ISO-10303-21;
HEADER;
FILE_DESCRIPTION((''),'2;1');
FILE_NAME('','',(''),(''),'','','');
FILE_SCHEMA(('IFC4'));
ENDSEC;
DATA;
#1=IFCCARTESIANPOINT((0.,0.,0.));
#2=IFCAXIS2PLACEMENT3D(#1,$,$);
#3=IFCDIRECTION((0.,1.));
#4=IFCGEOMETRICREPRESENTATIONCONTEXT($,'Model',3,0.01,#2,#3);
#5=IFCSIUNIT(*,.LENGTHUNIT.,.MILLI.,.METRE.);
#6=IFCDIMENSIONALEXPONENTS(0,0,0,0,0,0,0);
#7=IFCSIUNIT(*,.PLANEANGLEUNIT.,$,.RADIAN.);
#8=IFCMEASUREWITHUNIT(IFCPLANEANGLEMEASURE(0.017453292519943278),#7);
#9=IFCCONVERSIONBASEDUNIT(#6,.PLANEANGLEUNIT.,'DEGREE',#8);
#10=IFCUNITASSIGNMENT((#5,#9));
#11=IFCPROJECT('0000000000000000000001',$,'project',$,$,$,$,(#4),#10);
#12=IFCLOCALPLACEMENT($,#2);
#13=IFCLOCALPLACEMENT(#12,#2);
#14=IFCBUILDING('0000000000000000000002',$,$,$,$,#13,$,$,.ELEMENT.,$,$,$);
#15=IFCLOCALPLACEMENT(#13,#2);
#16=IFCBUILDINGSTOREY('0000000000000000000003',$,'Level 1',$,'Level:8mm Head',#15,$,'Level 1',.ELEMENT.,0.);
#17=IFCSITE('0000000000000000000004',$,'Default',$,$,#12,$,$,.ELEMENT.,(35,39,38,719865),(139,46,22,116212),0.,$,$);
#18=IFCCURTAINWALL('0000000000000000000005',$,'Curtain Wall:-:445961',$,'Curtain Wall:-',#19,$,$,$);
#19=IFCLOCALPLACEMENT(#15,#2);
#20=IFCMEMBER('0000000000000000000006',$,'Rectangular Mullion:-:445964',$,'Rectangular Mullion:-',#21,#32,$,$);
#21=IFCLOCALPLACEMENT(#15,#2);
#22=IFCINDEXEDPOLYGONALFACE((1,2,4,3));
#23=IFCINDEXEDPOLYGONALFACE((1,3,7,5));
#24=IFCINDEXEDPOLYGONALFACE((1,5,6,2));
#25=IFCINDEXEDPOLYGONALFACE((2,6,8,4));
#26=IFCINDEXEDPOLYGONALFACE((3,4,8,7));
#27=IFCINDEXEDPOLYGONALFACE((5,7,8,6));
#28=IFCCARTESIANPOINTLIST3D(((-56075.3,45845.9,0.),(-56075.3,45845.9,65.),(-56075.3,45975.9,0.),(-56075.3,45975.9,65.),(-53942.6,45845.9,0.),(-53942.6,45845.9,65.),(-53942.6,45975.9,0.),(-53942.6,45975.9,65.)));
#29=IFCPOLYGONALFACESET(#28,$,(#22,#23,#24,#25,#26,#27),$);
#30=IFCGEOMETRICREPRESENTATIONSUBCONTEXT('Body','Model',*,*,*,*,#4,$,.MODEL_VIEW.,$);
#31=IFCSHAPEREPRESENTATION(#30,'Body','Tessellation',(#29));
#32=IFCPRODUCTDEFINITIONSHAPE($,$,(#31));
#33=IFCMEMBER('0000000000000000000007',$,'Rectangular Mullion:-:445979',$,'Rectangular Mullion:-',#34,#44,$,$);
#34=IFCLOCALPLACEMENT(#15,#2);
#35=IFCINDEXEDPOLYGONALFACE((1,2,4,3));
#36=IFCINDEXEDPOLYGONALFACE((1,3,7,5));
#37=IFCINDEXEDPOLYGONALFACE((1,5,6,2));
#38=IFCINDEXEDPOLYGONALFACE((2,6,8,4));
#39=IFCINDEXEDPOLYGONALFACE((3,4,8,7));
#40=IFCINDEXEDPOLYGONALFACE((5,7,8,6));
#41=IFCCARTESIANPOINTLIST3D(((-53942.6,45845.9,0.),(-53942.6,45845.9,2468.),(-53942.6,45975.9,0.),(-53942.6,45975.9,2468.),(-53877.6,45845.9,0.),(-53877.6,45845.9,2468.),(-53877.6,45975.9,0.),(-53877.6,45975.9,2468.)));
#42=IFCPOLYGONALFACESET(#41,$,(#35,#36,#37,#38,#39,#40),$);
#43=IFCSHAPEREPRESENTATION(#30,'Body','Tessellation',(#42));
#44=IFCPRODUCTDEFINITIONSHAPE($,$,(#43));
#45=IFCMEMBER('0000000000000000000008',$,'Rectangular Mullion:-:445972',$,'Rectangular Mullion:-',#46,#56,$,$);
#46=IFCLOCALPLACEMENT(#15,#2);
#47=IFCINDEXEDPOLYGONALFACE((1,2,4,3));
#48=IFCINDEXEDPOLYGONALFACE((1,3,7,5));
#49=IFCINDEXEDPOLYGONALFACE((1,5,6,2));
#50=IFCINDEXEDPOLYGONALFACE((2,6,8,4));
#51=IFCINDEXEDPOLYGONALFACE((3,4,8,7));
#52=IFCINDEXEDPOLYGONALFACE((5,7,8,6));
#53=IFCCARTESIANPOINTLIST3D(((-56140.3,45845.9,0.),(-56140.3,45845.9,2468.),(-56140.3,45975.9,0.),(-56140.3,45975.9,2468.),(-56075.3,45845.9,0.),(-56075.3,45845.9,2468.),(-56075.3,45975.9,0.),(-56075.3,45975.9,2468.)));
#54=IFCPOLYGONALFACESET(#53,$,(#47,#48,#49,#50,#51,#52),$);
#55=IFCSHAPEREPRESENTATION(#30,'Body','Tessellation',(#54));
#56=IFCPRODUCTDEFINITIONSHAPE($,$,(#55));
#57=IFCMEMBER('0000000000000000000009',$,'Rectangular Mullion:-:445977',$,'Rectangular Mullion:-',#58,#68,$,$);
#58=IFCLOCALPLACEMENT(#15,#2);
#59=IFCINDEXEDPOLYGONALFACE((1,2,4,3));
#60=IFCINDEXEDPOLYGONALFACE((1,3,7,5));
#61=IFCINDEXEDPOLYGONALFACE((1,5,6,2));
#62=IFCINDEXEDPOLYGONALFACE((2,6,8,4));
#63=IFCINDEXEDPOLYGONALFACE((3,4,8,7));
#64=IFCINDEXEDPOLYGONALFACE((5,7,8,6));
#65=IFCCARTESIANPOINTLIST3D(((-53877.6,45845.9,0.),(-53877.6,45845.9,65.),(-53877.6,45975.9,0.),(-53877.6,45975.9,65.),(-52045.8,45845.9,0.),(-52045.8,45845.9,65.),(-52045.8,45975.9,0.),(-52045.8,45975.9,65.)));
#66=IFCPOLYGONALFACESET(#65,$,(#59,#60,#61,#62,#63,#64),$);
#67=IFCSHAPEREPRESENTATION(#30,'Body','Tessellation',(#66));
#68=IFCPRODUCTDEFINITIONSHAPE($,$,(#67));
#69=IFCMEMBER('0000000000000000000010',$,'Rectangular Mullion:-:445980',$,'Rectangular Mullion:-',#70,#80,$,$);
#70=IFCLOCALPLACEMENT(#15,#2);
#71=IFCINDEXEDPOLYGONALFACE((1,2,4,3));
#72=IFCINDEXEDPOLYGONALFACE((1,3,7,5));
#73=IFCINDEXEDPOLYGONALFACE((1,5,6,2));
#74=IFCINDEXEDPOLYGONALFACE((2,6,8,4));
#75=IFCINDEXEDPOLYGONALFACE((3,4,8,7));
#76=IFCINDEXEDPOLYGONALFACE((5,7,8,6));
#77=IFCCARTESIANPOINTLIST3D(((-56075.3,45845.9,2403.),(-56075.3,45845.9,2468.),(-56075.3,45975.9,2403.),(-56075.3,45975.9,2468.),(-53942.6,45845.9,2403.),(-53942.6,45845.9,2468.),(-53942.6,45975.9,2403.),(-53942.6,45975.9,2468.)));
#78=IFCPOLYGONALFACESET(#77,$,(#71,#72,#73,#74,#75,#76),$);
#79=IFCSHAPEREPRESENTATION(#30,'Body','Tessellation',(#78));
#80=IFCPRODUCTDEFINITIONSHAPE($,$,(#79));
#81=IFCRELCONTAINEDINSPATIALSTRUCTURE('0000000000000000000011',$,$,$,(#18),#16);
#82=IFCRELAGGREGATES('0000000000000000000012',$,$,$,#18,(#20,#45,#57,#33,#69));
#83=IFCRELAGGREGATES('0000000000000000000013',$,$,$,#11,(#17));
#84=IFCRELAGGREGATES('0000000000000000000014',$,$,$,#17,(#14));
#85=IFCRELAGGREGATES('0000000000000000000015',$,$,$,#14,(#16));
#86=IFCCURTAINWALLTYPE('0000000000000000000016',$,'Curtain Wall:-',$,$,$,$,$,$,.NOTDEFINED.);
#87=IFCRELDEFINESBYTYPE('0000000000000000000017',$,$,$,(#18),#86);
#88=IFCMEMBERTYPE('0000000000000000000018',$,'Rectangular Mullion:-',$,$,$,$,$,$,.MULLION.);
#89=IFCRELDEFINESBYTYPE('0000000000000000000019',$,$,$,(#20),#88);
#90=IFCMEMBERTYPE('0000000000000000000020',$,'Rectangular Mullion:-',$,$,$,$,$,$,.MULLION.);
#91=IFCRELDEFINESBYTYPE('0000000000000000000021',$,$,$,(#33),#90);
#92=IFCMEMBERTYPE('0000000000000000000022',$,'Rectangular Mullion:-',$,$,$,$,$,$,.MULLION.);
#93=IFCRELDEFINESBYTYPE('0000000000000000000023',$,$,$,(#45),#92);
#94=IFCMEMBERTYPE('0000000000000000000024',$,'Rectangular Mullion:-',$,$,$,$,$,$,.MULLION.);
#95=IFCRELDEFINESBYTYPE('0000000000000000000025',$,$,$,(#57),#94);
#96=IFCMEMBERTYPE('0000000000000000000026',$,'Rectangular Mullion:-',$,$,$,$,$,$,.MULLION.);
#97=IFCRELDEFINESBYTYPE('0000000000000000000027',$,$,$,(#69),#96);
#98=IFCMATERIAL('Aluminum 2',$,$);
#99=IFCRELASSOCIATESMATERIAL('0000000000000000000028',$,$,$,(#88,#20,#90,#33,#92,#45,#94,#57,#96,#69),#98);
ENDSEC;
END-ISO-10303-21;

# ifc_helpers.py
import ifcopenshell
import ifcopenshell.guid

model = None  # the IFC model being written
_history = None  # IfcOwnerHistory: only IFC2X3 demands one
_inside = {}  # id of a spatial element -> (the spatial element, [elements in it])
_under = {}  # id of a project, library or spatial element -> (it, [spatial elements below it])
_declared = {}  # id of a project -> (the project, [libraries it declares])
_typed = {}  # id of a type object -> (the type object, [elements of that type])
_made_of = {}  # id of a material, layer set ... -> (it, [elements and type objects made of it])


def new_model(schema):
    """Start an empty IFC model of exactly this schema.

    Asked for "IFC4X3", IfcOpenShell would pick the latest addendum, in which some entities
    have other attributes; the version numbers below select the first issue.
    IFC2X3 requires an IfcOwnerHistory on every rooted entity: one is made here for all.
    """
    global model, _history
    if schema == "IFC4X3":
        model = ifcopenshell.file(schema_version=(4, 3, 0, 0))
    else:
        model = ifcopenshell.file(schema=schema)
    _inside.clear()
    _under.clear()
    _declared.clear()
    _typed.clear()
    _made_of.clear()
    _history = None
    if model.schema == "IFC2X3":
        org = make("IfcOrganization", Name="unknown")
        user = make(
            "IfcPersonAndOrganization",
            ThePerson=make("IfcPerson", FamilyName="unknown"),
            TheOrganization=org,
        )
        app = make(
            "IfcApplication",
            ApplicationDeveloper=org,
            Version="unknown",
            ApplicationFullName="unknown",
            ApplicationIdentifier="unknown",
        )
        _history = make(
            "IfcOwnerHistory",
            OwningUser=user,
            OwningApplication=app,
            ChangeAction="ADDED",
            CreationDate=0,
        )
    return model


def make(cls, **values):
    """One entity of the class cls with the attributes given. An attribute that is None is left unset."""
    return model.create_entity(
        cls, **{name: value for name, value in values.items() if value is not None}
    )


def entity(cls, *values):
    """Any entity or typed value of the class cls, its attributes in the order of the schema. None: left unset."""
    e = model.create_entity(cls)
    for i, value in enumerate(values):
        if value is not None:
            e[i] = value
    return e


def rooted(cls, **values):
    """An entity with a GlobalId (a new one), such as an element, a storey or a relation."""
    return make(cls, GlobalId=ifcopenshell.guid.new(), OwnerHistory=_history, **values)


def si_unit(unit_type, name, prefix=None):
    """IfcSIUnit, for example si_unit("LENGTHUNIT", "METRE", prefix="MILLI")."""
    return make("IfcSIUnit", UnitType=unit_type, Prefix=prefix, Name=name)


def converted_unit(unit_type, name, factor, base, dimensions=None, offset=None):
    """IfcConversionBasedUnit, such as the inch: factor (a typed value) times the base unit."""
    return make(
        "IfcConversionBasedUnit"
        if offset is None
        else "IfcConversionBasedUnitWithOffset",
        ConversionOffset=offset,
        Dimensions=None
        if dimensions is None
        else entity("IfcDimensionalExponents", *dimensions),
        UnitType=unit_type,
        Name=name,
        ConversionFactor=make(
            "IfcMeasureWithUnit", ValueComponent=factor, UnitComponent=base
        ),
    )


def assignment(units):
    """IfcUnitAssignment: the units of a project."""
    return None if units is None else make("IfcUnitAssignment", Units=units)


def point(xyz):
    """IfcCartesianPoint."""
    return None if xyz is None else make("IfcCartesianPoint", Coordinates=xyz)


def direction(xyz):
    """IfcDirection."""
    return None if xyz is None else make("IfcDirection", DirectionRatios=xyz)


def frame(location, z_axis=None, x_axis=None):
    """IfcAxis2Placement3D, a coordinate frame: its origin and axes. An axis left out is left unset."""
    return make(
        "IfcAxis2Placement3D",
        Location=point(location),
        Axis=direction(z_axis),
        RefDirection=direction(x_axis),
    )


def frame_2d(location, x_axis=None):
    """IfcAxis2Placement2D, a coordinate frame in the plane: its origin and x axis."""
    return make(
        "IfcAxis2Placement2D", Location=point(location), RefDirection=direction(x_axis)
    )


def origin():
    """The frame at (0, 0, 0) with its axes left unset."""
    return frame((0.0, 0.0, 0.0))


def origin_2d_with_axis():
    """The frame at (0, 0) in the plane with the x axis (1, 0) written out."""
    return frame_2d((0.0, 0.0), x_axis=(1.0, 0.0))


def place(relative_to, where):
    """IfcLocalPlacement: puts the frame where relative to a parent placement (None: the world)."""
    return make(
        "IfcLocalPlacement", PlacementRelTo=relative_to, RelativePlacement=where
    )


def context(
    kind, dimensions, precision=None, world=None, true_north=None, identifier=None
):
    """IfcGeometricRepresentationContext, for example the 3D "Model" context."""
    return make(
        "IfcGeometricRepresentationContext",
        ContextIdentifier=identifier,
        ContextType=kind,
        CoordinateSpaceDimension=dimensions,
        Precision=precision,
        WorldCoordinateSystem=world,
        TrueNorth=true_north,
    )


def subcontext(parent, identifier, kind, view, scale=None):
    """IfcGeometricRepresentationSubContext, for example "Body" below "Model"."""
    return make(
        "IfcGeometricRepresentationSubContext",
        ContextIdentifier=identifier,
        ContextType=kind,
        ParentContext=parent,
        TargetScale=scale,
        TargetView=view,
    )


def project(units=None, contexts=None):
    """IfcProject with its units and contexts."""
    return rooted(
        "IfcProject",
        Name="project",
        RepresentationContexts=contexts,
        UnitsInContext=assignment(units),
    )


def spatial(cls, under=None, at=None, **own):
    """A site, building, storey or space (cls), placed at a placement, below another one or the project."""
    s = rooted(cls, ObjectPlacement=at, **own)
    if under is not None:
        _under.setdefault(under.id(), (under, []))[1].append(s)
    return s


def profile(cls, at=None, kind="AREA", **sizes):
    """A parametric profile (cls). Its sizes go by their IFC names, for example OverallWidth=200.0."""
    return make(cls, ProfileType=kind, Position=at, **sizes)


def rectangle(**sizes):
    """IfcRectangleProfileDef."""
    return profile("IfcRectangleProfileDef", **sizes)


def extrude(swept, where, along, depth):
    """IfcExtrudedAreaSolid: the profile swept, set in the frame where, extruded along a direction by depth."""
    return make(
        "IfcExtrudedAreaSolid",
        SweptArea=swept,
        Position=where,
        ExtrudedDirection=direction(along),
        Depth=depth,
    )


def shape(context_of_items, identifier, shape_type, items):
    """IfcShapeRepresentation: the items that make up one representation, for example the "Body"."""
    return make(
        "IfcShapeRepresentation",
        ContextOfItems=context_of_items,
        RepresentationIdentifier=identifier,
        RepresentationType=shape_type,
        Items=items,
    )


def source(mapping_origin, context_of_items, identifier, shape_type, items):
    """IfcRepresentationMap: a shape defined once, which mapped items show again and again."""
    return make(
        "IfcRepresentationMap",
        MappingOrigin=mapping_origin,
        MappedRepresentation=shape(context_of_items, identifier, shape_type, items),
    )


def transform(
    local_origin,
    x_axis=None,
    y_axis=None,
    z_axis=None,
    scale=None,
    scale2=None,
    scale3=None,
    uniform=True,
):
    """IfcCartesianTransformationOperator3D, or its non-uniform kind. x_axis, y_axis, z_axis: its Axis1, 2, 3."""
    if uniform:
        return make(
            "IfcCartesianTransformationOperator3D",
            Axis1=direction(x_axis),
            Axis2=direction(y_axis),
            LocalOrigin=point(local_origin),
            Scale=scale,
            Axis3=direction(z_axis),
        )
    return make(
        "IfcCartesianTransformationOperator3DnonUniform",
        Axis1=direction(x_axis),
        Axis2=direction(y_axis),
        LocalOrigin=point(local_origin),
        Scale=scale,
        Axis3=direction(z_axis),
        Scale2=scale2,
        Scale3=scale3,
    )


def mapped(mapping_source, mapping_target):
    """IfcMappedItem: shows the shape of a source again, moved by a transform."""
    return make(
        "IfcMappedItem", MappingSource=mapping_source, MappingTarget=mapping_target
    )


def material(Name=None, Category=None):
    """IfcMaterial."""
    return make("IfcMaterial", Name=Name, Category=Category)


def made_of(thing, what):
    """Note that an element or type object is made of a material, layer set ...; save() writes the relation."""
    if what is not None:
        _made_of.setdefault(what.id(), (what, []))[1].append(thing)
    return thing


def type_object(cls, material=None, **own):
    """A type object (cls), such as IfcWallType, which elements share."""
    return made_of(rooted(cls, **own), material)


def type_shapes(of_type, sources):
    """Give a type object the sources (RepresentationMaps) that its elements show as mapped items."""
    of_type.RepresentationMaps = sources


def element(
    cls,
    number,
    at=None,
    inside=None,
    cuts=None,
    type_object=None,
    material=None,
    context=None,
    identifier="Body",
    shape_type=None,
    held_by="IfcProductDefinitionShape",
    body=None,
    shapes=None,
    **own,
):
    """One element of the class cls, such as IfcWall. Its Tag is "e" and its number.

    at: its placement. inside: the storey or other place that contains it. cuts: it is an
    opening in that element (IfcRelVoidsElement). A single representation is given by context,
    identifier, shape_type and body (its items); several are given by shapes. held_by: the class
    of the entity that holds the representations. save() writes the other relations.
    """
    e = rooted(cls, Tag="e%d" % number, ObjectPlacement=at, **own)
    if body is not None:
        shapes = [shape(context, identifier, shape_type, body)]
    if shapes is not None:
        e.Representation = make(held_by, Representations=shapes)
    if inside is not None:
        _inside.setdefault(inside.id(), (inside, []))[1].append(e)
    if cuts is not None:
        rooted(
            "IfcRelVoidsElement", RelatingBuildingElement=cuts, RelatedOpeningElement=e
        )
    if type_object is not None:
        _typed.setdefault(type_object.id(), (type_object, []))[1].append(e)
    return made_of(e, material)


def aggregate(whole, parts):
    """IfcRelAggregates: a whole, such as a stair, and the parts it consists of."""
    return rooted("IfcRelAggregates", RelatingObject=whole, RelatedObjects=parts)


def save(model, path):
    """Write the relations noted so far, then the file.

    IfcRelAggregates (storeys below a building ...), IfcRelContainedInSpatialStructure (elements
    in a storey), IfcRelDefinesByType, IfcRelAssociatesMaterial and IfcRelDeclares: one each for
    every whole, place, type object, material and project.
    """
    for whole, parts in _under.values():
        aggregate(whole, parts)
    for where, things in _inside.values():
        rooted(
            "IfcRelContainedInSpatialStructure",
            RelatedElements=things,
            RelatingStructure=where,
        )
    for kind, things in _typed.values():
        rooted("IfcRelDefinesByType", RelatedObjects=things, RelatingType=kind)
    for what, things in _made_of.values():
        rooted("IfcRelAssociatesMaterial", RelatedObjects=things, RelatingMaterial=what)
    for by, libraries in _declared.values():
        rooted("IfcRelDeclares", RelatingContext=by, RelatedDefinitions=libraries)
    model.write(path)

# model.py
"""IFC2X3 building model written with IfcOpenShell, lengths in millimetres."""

from ifc_helpers import new_model, entity, si_unit, converted_unit, direction, frame, frame_2d, origin, origin_2d_with_axis, place, context, subcontext, project, spatial, rectangle, extrude, source, transform, mapped, material, type_object, type_shapes, element, aggregate, save


model = new_model("IFC2X3")

# Units and contexts
model_context = context("Model", 3, precision=0.01, world=origin(), true_north=direction((0.0, 1.0)))
body_context = subcontext(model_context, "Body", "Model", "MODEL_VIEW")
ifc_project = project(units=[si_unit("LENGTHUNIT", "METRE", prefix="MILLI"), converted_unit("PLANEANGLEUNIT", "DEGREE", entity("IfcPlaneAngleMeasure", 0.017453292519943278), si_unit("PLANEANGLEUNIT", "RADIAN"), dimensions=[0, 0, 0, 0, 0, 0, 0])], contexts=[model_context])

# Site, building, storey
site_placement = place(None, origin())
site = spatial("IfcSite", under=ifc_project, at=site_placement, Name="Default", CompositionType="ELEMENT", RefLatitude=(35, 39, 38, 719865), RefLongitude=(139, 46, 22, 116212), RefElevation=0.0)
building_placement = place(site_placement, origin())
building = spatial("IfcBuilding", under=site, at=building_placement, CompositionType="ELEMENT")
storey_placement = place(building_placement, origin())
storey = spatial("IfcBuildingStorey", under=building, at=storey_placement, Name="Level 1", ObjectType="Level:8mm Head", LongName="Level 1", CompositionType="ELEMENT", Elevation=0.0)

# Curtain wall, members
curtain_wall_type = type_object("IfcCurtainWallType", Name="Curtain Wall:-", PredefinedType="NOTDEFINED")
curtain_wall_placement = place(storey_placement, origin())
curtain_wall = element("IfcCurtainWall", 1, at=curtain_wall_placement, inside=storey, type_object=curtain_wall_type, Name="Curtain Wall:-:445961", ObjectType="Curtain Wall:-")
ifc_material_1 = material(Name="Aluminum 2")
member_type_1 = type_object("IfcMemberType", Name="Rectangular Mullion:-", PredefinedType="MULLION", material=ifc_material_1)
shared_shape_1 = source(origin(), body_context, "Body", "SweptSolid", [
    extrude(rectangle(XDim=65.0, YDim=130.0, at=origin_2d_with_axis()), frame((-32.5, 0.0, -2132.6), z_axis=(0.0, 0.0, 1.0), x_axis=(-1.0, 0.0, 0.0)), (0.0, 0.0, 1.0), 2132.6),
])
type_shapes(member_type_1, [shared_shape_1])
member_1_placement = place(curtain_wall_placement, frame((-56075.3, 45910.9, 0.0), z_axis=(-1.0, 0.0, 0.0), x_axis=(0.0, 0.0, -1.0)))
member_1 = element("IfcMember", 2, at=member_1_placement, type_object=member_type_1, material=ifc_material_1, Name="Rectangular Mullion:-:445964", ObjectType="Rectangular Mullion:-", context=body_context, shape_type="MappedRepresentation", body=[
    mapped(shared_shape_1, transform((0.0, 0.0, 0.0), scale=1.0)),
])
member_type_2 = type_object("IfcMemberType", Name="Rectangular Mullion:-", PredefinedType="MULLION", material=ifc_material_1)
shared_shape_2 = source(origin(), body_context, "Body", "SweptSolid", [
    extrude(rectangle(XDim=65.0, YDim=130.0, at=frame_2d((0.0, 0.0), x_axis=(1.0, 0.0))), frame((0.0, 0.0, -2468.0), z_axis=(0.0, 0.0, 1.0), x_axis=(-1.0, 0.0, 0.0)), (0.0, 0.0, 1.0), 2468.0),
])
type_shapes(member_type_2, [shared_shape_2])
member_2_placement = place(curtain_wall_placement, frame((-53910.1, 45910.9, 0.0), z_axis=(0.0, 0.0, -1.0), x_axis=(1.0, 0.0, 0.0)))
member_2 = element("IfcMember", 3, at=member_2_placement, type_object=member_type_2, material=ifc_material_1, Name="Rectangular Mullion:-:445979", ObjectType="Rectangular Mullion:-", context=body_context, shape_type="MappedRepresentation", body=[
    mapped(shared_shape_2, transform((0.0, 0.0, 0.0), scale=1.0)),
])
member_type_3 = type_object("IfcMemberType", Name="Rectangular Mullion:-", PredefinedType="MULLION", material=ifc_material_1)
shared_shape_3 = source(origin(), body_context, "Body", "SweptSolid", [
    extrude(rectangle(XDim=65.0, YDim=130.0, at=frame_2d((0.0, 0.0), x_axis=(1.0, 0.0))), frame((-32.5, 0.0, -2468.0), z_axis=(0.0, 0.0, 1.0), x_axis=(-1.0, 0.0, 0.0)), (0.0, 0.0, 1.0), 2468.0),
])
type_shapes(member_type_3, [shared_shape_3])
member_3_placement = place(curtain_wall_placement, frame((-56140.3, 45910.9, 2468.0), z_axis=(0.0, 0.0, 1.0), x_axis=(-1.0, 0.0, 0.0)))
member_3 = element("IfcMember", 4, at=member_3_placement, type_object=member_type_3, material=ifc_material_1, Name="Rectangular Mullion:-:445972", ObjectType="Rectangular Mullion:-", context=body_context, shape_type="MappedRepresentation", body=[
    mapped(shared_shape_3, transform((0.0, 0.0, 0.0), scale=1.0)),
])
member_type_4 = type_object("IfcMemberType", Name="Rectangular Mullion:-", PredefinedType="MULLION", material=ifc_material_1)
shared_shape_4 = source(origin(), body_context, "Body", "SweptSolid", [
    extrude(rectangle(XDim=65.0, YDim=130.0, at=frame_2d((0.0, 0.0), x_axis=(1.0, 0.0))), frame((-32.5, 0.0, -1831.9), z_axis=(0.0, 0.0, 1.0), x_axis=(-1.0, 0.0, 0.0)), (0.0, 0.0, 1.0), 1831.9),
])
type_shapes(member_type_4, [shared_shape_4])
member_4_placement = place(curtain_wall_placement, frame((-53877.6, 45910.9, 0.0), z_axis=(-1.0, 0.0, 0.0), x_axis=(0.0, 0.0, -1.0)))
member_4 = element("IfcMember", 5, at=member_4_placement, type_object=member_type_4, material=ifc_material_1, Name="Rectangular Mullion:-:445977", ObjectType="Rectangular Mullion:-", context=body_context, shape_type="MappedRepresentation", body=[
    mapped(shared_shape_4, transform((0.0, 0.0, 0.0), scale=1.0)),
])
member_type_5 = type_object("IfcMemberType", Name="Rectangular Mullion:-", PredefinedType="MULLION", material=ifc_material_1)
shared_shape_5 = source(origin(), body_context, "Body", "SweptSolid", [
    extrude(rectangle(XDim=65.0, YDim=130.0, at=origin_2d_with_axis()), frame((0.0, 0.0, -2132.6), z_axis=(0.0, 0.0, 1.0), x_axis=(-1.0, 0.0, 0.0)), (0.0, 0.0, 1.0), 2132.6),
])
type_shapes(member_type_5, [shared_shape_5])
member_5_placement = place(curtain_wall_placement, frame((-53942.6, 45910.9, 2435.5), z_axis=(1.0, 0.0, 0.0), x_axis=(0.0, 0.0, 1.0)))
member_5 = element("IfcMember", 6, at=member_5_placement, type_object=member_type_5, material=ifc_material_1, Name="Rectangular Mullion:-:445980", ObjectType="Rectangular Mullion:-", context=body_context, shape_type="MappedRepresentation", body=[
    mapped(shared_shape_5, transform((0.0, 0.0, 0.0), scale=1.0)),
])
aggregate(curtain_wall, [member_1, member_3, member_4, member_2, member_5])

save(model, "model.ifc")
